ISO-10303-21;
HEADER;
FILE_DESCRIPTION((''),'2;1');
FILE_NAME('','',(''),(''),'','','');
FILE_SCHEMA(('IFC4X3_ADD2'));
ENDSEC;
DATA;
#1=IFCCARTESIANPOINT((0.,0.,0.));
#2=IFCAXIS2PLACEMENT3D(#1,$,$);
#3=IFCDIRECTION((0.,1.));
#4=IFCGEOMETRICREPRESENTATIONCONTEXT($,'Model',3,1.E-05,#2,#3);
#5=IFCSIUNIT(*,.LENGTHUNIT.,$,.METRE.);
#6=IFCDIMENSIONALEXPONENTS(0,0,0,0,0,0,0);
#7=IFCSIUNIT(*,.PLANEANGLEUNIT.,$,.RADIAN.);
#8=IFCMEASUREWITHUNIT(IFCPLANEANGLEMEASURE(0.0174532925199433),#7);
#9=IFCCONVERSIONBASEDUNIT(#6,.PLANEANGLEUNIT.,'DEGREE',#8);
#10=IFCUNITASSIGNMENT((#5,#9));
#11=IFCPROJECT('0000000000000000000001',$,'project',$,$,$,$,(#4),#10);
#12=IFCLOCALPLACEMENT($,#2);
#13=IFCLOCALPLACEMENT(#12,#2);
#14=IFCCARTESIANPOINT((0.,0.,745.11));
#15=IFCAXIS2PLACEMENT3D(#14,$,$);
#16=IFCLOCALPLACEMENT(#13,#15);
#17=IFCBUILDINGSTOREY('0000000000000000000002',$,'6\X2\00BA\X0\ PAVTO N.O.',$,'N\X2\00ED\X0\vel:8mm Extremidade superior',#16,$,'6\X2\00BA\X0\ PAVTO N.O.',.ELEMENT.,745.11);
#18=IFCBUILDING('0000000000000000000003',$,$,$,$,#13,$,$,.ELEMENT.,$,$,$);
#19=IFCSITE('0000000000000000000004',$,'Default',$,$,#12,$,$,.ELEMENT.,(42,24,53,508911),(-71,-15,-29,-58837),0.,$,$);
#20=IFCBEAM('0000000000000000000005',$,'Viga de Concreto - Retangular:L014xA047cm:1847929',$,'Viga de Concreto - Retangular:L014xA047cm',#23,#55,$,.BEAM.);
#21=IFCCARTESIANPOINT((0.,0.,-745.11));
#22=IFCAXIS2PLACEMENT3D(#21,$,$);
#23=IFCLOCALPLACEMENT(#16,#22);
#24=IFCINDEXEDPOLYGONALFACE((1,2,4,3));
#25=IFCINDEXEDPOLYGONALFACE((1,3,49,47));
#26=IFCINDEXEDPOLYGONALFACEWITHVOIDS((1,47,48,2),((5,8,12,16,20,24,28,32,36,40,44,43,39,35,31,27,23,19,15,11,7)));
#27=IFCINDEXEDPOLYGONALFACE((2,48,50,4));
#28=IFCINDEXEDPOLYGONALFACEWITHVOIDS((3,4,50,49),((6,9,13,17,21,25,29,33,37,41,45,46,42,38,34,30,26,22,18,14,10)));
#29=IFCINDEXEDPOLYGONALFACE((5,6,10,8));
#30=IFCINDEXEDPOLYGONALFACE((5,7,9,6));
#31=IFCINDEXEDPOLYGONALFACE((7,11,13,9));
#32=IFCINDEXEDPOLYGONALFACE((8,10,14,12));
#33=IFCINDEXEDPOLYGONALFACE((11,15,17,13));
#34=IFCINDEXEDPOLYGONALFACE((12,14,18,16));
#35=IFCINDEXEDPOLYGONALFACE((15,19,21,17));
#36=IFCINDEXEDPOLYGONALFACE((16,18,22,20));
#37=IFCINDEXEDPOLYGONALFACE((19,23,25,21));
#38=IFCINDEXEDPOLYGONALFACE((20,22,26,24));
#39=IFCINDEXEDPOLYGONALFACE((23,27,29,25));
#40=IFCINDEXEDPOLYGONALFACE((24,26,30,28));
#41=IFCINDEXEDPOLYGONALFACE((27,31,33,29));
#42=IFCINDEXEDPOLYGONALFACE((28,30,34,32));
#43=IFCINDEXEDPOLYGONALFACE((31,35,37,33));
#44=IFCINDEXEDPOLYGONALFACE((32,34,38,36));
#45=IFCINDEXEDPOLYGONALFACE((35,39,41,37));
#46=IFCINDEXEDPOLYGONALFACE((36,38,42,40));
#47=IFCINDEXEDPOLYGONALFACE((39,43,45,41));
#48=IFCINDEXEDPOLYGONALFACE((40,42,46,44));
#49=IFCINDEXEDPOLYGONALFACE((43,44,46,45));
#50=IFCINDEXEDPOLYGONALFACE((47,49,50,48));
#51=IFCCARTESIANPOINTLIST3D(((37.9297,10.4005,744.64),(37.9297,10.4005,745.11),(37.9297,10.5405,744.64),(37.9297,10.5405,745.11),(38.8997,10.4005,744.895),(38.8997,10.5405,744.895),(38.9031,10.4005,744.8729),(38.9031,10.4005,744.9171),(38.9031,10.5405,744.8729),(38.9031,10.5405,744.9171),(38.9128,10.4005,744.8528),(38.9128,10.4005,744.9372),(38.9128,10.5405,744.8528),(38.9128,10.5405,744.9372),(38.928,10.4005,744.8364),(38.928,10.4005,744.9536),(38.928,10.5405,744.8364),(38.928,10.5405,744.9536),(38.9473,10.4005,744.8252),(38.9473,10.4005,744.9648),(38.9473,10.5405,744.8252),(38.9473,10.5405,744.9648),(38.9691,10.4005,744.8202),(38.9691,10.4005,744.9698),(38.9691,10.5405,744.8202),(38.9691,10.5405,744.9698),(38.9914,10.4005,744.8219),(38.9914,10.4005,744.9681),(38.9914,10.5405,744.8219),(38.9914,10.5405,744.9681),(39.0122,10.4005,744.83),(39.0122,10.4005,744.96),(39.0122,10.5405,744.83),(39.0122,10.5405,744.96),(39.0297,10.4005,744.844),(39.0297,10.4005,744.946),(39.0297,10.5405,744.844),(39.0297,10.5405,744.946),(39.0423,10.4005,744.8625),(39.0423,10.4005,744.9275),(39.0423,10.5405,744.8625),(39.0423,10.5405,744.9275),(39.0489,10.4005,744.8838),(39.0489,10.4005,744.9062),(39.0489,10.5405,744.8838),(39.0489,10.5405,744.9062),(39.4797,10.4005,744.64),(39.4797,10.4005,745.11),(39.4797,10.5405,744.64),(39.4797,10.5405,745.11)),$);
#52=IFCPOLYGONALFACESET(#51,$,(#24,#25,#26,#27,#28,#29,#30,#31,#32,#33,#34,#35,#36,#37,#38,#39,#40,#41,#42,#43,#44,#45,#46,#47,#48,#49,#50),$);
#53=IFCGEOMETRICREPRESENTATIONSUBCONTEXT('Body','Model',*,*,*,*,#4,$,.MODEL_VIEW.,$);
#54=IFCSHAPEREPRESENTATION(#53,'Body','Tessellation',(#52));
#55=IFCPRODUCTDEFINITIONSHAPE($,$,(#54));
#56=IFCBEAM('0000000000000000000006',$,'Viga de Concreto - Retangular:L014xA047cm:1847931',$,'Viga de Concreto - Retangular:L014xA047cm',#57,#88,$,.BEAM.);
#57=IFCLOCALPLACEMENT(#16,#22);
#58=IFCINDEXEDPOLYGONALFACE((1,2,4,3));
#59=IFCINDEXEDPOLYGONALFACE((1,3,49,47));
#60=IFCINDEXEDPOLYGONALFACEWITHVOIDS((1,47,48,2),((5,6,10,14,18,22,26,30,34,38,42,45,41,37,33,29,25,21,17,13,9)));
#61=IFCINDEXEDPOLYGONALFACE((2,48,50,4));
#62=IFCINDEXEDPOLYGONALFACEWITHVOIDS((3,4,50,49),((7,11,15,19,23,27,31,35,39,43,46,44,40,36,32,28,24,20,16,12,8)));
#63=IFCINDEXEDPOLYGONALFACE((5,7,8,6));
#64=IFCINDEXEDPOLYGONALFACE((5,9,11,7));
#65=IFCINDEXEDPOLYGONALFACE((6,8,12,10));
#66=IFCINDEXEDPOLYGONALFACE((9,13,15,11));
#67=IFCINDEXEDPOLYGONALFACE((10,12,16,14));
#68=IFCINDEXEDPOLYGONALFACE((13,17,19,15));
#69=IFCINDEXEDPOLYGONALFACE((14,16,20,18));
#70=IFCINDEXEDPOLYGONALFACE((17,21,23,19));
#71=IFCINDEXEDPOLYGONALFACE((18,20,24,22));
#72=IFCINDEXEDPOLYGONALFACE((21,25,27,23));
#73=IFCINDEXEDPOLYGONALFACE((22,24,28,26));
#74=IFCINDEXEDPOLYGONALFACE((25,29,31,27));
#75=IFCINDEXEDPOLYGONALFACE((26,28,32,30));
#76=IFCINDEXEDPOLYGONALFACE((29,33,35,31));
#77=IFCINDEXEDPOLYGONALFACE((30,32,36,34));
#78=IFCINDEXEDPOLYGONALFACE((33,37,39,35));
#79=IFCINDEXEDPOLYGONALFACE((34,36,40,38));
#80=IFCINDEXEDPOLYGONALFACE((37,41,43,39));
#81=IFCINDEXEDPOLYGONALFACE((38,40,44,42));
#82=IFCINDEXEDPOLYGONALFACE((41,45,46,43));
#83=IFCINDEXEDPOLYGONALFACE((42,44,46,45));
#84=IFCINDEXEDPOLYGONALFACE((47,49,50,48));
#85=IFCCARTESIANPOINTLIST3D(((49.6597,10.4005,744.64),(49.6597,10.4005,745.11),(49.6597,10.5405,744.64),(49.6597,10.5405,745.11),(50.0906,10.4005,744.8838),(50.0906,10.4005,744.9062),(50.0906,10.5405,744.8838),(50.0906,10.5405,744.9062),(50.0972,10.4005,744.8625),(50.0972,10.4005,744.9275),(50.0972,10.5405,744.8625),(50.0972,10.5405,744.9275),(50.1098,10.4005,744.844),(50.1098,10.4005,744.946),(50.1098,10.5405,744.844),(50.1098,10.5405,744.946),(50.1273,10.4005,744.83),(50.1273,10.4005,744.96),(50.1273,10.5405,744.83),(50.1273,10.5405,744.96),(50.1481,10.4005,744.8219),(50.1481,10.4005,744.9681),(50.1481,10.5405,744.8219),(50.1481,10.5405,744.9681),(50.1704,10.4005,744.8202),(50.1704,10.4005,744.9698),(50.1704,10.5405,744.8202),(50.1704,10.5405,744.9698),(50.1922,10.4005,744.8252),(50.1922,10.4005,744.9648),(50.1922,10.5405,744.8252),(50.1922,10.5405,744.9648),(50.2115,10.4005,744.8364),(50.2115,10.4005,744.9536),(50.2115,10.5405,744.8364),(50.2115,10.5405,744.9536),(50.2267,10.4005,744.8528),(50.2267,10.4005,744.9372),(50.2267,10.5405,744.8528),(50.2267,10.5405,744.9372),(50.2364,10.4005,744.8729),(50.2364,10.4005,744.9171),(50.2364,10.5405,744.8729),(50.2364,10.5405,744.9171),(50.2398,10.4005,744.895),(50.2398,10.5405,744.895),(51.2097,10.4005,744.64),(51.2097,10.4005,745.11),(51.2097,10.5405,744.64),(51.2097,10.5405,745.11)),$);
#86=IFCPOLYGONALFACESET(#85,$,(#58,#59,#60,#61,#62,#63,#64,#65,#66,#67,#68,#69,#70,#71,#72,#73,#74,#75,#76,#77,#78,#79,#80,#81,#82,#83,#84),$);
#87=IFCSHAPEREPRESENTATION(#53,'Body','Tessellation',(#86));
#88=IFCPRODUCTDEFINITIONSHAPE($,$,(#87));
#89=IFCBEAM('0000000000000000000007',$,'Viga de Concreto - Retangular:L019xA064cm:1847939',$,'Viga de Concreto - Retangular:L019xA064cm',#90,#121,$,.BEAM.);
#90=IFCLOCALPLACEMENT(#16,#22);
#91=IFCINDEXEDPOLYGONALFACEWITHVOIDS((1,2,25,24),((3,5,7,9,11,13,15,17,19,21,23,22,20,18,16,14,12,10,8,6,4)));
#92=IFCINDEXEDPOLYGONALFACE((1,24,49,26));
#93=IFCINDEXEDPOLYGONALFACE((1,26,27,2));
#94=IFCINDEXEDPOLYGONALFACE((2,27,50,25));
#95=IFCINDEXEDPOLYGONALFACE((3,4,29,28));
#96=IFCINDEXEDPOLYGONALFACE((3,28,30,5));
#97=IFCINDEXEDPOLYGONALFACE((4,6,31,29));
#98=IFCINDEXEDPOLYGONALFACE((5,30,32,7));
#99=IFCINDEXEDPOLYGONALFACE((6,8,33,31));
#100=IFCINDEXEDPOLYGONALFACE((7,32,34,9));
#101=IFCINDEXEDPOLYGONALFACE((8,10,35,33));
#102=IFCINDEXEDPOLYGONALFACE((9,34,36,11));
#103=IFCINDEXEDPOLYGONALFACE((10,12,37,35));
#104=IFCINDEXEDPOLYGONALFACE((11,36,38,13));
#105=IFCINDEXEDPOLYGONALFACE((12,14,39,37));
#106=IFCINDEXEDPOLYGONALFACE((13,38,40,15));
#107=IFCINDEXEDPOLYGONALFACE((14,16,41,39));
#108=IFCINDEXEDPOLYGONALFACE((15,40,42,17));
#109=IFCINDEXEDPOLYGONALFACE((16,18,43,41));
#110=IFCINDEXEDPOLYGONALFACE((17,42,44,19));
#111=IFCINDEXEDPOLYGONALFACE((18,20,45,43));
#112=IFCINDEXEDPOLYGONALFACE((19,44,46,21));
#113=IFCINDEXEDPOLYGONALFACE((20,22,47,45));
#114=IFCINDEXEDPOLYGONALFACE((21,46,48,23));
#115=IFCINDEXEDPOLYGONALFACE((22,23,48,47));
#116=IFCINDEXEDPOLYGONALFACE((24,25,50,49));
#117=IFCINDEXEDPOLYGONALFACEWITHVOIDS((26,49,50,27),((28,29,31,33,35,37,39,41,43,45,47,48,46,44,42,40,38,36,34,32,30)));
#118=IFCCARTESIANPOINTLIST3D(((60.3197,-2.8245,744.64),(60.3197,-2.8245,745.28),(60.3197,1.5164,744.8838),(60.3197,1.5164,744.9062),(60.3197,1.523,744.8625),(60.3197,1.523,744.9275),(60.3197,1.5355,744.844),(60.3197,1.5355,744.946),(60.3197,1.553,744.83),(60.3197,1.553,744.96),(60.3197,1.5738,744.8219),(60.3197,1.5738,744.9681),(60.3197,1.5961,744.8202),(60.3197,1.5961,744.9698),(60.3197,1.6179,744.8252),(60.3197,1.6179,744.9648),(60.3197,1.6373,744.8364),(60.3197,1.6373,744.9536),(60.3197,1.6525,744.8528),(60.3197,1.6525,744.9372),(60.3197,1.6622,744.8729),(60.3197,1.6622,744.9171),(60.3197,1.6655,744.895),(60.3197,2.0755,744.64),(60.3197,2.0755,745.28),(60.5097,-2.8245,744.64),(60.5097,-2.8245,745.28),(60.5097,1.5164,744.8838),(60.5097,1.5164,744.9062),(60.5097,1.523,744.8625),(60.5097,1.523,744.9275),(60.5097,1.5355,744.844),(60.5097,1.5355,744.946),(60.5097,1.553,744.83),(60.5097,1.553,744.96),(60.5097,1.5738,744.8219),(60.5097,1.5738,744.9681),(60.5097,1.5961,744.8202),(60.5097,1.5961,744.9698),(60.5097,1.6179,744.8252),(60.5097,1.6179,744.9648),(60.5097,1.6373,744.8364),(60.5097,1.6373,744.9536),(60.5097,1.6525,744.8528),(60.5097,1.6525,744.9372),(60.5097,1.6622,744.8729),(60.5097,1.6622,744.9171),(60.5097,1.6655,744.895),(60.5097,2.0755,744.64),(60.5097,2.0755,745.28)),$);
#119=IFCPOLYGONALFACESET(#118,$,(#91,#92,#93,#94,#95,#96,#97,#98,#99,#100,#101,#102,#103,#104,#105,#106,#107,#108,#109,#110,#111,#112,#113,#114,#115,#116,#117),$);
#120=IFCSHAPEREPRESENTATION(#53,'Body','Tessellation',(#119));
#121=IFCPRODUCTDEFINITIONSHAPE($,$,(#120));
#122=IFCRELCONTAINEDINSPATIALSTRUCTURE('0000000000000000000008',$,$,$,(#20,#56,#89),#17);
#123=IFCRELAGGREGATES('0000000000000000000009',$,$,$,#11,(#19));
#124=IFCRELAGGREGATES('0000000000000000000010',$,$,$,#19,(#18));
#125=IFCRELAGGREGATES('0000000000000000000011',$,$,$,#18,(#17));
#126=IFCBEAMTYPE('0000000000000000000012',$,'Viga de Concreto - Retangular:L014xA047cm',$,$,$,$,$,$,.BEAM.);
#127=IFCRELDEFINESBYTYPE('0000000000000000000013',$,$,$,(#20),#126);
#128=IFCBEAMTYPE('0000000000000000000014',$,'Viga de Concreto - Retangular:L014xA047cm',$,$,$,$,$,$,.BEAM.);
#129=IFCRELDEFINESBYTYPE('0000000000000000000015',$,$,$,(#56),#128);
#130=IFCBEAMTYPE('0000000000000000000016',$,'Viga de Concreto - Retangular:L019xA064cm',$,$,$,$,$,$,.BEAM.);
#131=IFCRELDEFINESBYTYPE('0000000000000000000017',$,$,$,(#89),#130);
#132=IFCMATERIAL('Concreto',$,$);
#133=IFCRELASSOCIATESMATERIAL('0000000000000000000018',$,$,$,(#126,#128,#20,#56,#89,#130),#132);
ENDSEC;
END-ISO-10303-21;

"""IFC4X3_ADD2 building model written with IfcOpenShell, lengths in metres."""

from ifc_helpers import new_model, entity, si_unit, converted_unit, direction, frame, frame_2d, origin, origin_2d_with_axis, place, context, subcontext, project, spatial, rectangle, circle, extrude, boolean, source, transform, mapped, material, material_profile, profile_set, type_object, type_shapes, element, save


model = new_model("IFC4X3_ADD2")

# Units and contexts
model_context = context("Model", 3, precision=1e-05, world=origin(), true_north=direction((0.0, 1.0)))
body_context = subcontext(model_context, "Body", "Model", "MODEL_VIEW")
ifc_project = project(units=[si_unit("LENGTHUNIT", "METRE"), converted_unit("PLANEANGLEUNIT", "DEGREE", entity("IfcPlaneAngleMeasure", 0.0174532925199433), si_unit("PLANEANGLEUNIT", "RADIAN"), dimensions=[0, 0, 0, 0, 0, 0, 0])], contexts=[model_context])

# Site, building, storey
site_placement = place(None, origin())
site = spatial("IfcSite", under=ifc_project, at=site_placement, Name="Default", CompositionType="ELEMENT", RefLatitude=(42, 24, 53, 508911), RefLongitude=(-71, -15, -29, -58837), RefElevation=0.0)
building_placement = place(site_placement, origin())
building = spatial("IfcBuilding", under=site, at=building_placement, CompositionType="ELEMENT")
storey_placement = place(building_placement, frame((0.0, 0.0, 745.11)))
storey = spatial("IfcBuildingStorey", under=building, at=storey_placement, Name="6º PAVTO N.O.", ObjectType="Nível:8mm Extremidade superior", LongName="6º PAVTO N.O.", CompositionType="ELEMENT", Elevation=745.11)

# Beams
ifc_material = material(Name="Concreto")
ifc_material_profile_1 = material_profile(ifc_material, rectangle(XDim=0.47, YDim=0.14, at=frame_2d((0.0, 0.0), x_axis=(0.0, 1.0))), Name="L014xA047cm")
ifc_profile_set_1 = profile_set([ifc_material_profile_1], Name="L014xA047cm")
beam_type_1 = type_object("IfcBeamType", Name="Viga de Concreto - Retangular:L014xA047cm", PredefinedType="BEAM", material=ifc_profile_set_1)
shared_shape_1 = source(origin(), body_context, "Body", "CSG", [
    boolean("DIFFERENCE", extrude(rectangle(XDim=0.47, YDim=0.14, at=frame_2d((0.0, 0.0), x_axis=(0.0, 1.0))), frame((37.9297, 10.4705, 744.875), z_axis=(1.0, 0.0, 0.0), x_axis=(0.0, 1.0, 0.0)), (0.0, 0.0, 1.0), 1.55), extrude(circle(Radius=0.075, at=frame_2d((0.0, 0.0), x_axis=(1.0, 0.0))), frame((38.9747, 10.5405, 744.895), z_axis=(0.0, -1.0, 0.0), x_axis=(-1.0, 0.0, 0.0)), (0.0, 0.0, 1.0), 0.14)),
])
type_shapes(beam_type_1, [shared_shape_1])
beam_1_placement = place(storey_placement, frame((0.0, 0.0, -745.11)))
element("IfcBeam", 1, at=beam_1_placement, inside=storey, type_object=beam_type_1, material=ifc_material, Name="Viga de Concreto - Retangular:L014xA047cm:1847929", ObjectType="Viga de Concreto - Retangular:L014xA047cm", PredefinedType="BEAM", context=body_context, shape_type="MappedRepresentation", body=[
    mapped(shared_shape_1, transform((0.0, 0.0, 0.0), scale=1.0)),
])
beam_type_2 = type_object("IfcBeamType", Name="Viga de Concreto - Retangular:L014xA047cm", PredefinedType="BEAM", material=ifc_profile_set_1)
shared_shape_2 = source(origin(), body_context, "Body", "CSG", [
    boolean("DIFFERENCE", extrude(rectangle(XDim=0.47, YDim=0.14, at=frame_2d((0.0, 0.0), x_axis=(0.0, 1.0))), frame((49.6597, 10.4705, 744.875), z_axis=(1.0, 0.0, 0.0), x_axis=(0.0, 1.0, 0.0)), (0.0, 0.0, 1.0), 1.55), extrude(circle(Radius=0.075, at=frame_2d((0.0, 0.0), x_axis=(1.0, 0.0))), frame((50.1648, 10.5405, 744.895), z_axis=(0.0, -1.0, 0.0), x_axis=(1.0, 0.0, 0.0)), (0.0, 0.0, 1.0), 0.14)),
])
type_shapes(beam_type_2, [shared_shape_2])
beam_2_placement = place(storey_placement, frame((0.0, 0.0, -745.11)))
element("IfcBeam", 2, at=beam_2_placement, inside=storey, type_object=beam_type_2, material=ifc_material, Name="Viga de Concreto - Retangular:L014xA047cm:1847931", ObjectType="Viga de Concreto - Retangular:L014xA047cm", PredefinedType="BEAM", context=body_context, shape_type="MappedRepresentation", body=[
    mapped(shared_shape_2, transform((0.0, 0.0, 0.0), scale=1.0)),
])
ifc_material_profile_2 = material_profile(ifc_material, rectangle(XDim=0.64, YDim=0.19, at=frame_2d((0.0, 0.0), x_axis=(1.0, 0.0))), Name="L019xA064cm")
ifc_profile_set_2 = profile_set([ifc_material_profile_2], Name="L019xA064cm")
beam_type_3 = type_object("IfcBeamType", Name="Viga de Concreto - Retangular:L019xA064cm", PredefinedType="BEAM", material=ifc_profile_set_2)
shared_shape_3 = source(origin(), body_context, "Body", "CSG", [
    boolean("DIFFERENCE", extrude(rectangle(XDim=0.64, YDim=0.19, at=frame_2d((0.0, 0.0), x_axis=(0.0, 1.0))), frame((60.4147, 2.0755, 744.96), z_axis=(0.0, -1.0, 0.0), x_axis=(-1.0, 0.0, 0.0)), (0.0, 0.0, 1.0), 4.9), extrude(circle(Radius=0.075, at=origin_2d_with_axis()), frame((60.3197, 1.5905, 744.895), z_axis=(1.0, 0.0, 0.0), x_axis=(0.0, 1.0, 0.0)), (0.0, 0.0, 1.0), 0.19)),
])
type_shapes(beam_type_3, [shared_shape_3])
beam_3_placement = place(storey_placement, frame((0.0, 0.0, -745.11)))
element("IfcBeam", 3, at=beam_3_placement, inside=storey, type_object=beam_type_3, material=ifc_material, Name="Viga de Concreto - Retangular:L019xA064cm:1847939", ObjectType="Viga de Concreto - Retangular:L019xA064cm", PredefinedType="BEAM", context=body_context, shape_type="MappedRepresentation", body=[
    mapped(shared_shape_3, transform((0.0, 0.0, 0.0), scale=1.0)),
])

save(model, "model.ifc")
